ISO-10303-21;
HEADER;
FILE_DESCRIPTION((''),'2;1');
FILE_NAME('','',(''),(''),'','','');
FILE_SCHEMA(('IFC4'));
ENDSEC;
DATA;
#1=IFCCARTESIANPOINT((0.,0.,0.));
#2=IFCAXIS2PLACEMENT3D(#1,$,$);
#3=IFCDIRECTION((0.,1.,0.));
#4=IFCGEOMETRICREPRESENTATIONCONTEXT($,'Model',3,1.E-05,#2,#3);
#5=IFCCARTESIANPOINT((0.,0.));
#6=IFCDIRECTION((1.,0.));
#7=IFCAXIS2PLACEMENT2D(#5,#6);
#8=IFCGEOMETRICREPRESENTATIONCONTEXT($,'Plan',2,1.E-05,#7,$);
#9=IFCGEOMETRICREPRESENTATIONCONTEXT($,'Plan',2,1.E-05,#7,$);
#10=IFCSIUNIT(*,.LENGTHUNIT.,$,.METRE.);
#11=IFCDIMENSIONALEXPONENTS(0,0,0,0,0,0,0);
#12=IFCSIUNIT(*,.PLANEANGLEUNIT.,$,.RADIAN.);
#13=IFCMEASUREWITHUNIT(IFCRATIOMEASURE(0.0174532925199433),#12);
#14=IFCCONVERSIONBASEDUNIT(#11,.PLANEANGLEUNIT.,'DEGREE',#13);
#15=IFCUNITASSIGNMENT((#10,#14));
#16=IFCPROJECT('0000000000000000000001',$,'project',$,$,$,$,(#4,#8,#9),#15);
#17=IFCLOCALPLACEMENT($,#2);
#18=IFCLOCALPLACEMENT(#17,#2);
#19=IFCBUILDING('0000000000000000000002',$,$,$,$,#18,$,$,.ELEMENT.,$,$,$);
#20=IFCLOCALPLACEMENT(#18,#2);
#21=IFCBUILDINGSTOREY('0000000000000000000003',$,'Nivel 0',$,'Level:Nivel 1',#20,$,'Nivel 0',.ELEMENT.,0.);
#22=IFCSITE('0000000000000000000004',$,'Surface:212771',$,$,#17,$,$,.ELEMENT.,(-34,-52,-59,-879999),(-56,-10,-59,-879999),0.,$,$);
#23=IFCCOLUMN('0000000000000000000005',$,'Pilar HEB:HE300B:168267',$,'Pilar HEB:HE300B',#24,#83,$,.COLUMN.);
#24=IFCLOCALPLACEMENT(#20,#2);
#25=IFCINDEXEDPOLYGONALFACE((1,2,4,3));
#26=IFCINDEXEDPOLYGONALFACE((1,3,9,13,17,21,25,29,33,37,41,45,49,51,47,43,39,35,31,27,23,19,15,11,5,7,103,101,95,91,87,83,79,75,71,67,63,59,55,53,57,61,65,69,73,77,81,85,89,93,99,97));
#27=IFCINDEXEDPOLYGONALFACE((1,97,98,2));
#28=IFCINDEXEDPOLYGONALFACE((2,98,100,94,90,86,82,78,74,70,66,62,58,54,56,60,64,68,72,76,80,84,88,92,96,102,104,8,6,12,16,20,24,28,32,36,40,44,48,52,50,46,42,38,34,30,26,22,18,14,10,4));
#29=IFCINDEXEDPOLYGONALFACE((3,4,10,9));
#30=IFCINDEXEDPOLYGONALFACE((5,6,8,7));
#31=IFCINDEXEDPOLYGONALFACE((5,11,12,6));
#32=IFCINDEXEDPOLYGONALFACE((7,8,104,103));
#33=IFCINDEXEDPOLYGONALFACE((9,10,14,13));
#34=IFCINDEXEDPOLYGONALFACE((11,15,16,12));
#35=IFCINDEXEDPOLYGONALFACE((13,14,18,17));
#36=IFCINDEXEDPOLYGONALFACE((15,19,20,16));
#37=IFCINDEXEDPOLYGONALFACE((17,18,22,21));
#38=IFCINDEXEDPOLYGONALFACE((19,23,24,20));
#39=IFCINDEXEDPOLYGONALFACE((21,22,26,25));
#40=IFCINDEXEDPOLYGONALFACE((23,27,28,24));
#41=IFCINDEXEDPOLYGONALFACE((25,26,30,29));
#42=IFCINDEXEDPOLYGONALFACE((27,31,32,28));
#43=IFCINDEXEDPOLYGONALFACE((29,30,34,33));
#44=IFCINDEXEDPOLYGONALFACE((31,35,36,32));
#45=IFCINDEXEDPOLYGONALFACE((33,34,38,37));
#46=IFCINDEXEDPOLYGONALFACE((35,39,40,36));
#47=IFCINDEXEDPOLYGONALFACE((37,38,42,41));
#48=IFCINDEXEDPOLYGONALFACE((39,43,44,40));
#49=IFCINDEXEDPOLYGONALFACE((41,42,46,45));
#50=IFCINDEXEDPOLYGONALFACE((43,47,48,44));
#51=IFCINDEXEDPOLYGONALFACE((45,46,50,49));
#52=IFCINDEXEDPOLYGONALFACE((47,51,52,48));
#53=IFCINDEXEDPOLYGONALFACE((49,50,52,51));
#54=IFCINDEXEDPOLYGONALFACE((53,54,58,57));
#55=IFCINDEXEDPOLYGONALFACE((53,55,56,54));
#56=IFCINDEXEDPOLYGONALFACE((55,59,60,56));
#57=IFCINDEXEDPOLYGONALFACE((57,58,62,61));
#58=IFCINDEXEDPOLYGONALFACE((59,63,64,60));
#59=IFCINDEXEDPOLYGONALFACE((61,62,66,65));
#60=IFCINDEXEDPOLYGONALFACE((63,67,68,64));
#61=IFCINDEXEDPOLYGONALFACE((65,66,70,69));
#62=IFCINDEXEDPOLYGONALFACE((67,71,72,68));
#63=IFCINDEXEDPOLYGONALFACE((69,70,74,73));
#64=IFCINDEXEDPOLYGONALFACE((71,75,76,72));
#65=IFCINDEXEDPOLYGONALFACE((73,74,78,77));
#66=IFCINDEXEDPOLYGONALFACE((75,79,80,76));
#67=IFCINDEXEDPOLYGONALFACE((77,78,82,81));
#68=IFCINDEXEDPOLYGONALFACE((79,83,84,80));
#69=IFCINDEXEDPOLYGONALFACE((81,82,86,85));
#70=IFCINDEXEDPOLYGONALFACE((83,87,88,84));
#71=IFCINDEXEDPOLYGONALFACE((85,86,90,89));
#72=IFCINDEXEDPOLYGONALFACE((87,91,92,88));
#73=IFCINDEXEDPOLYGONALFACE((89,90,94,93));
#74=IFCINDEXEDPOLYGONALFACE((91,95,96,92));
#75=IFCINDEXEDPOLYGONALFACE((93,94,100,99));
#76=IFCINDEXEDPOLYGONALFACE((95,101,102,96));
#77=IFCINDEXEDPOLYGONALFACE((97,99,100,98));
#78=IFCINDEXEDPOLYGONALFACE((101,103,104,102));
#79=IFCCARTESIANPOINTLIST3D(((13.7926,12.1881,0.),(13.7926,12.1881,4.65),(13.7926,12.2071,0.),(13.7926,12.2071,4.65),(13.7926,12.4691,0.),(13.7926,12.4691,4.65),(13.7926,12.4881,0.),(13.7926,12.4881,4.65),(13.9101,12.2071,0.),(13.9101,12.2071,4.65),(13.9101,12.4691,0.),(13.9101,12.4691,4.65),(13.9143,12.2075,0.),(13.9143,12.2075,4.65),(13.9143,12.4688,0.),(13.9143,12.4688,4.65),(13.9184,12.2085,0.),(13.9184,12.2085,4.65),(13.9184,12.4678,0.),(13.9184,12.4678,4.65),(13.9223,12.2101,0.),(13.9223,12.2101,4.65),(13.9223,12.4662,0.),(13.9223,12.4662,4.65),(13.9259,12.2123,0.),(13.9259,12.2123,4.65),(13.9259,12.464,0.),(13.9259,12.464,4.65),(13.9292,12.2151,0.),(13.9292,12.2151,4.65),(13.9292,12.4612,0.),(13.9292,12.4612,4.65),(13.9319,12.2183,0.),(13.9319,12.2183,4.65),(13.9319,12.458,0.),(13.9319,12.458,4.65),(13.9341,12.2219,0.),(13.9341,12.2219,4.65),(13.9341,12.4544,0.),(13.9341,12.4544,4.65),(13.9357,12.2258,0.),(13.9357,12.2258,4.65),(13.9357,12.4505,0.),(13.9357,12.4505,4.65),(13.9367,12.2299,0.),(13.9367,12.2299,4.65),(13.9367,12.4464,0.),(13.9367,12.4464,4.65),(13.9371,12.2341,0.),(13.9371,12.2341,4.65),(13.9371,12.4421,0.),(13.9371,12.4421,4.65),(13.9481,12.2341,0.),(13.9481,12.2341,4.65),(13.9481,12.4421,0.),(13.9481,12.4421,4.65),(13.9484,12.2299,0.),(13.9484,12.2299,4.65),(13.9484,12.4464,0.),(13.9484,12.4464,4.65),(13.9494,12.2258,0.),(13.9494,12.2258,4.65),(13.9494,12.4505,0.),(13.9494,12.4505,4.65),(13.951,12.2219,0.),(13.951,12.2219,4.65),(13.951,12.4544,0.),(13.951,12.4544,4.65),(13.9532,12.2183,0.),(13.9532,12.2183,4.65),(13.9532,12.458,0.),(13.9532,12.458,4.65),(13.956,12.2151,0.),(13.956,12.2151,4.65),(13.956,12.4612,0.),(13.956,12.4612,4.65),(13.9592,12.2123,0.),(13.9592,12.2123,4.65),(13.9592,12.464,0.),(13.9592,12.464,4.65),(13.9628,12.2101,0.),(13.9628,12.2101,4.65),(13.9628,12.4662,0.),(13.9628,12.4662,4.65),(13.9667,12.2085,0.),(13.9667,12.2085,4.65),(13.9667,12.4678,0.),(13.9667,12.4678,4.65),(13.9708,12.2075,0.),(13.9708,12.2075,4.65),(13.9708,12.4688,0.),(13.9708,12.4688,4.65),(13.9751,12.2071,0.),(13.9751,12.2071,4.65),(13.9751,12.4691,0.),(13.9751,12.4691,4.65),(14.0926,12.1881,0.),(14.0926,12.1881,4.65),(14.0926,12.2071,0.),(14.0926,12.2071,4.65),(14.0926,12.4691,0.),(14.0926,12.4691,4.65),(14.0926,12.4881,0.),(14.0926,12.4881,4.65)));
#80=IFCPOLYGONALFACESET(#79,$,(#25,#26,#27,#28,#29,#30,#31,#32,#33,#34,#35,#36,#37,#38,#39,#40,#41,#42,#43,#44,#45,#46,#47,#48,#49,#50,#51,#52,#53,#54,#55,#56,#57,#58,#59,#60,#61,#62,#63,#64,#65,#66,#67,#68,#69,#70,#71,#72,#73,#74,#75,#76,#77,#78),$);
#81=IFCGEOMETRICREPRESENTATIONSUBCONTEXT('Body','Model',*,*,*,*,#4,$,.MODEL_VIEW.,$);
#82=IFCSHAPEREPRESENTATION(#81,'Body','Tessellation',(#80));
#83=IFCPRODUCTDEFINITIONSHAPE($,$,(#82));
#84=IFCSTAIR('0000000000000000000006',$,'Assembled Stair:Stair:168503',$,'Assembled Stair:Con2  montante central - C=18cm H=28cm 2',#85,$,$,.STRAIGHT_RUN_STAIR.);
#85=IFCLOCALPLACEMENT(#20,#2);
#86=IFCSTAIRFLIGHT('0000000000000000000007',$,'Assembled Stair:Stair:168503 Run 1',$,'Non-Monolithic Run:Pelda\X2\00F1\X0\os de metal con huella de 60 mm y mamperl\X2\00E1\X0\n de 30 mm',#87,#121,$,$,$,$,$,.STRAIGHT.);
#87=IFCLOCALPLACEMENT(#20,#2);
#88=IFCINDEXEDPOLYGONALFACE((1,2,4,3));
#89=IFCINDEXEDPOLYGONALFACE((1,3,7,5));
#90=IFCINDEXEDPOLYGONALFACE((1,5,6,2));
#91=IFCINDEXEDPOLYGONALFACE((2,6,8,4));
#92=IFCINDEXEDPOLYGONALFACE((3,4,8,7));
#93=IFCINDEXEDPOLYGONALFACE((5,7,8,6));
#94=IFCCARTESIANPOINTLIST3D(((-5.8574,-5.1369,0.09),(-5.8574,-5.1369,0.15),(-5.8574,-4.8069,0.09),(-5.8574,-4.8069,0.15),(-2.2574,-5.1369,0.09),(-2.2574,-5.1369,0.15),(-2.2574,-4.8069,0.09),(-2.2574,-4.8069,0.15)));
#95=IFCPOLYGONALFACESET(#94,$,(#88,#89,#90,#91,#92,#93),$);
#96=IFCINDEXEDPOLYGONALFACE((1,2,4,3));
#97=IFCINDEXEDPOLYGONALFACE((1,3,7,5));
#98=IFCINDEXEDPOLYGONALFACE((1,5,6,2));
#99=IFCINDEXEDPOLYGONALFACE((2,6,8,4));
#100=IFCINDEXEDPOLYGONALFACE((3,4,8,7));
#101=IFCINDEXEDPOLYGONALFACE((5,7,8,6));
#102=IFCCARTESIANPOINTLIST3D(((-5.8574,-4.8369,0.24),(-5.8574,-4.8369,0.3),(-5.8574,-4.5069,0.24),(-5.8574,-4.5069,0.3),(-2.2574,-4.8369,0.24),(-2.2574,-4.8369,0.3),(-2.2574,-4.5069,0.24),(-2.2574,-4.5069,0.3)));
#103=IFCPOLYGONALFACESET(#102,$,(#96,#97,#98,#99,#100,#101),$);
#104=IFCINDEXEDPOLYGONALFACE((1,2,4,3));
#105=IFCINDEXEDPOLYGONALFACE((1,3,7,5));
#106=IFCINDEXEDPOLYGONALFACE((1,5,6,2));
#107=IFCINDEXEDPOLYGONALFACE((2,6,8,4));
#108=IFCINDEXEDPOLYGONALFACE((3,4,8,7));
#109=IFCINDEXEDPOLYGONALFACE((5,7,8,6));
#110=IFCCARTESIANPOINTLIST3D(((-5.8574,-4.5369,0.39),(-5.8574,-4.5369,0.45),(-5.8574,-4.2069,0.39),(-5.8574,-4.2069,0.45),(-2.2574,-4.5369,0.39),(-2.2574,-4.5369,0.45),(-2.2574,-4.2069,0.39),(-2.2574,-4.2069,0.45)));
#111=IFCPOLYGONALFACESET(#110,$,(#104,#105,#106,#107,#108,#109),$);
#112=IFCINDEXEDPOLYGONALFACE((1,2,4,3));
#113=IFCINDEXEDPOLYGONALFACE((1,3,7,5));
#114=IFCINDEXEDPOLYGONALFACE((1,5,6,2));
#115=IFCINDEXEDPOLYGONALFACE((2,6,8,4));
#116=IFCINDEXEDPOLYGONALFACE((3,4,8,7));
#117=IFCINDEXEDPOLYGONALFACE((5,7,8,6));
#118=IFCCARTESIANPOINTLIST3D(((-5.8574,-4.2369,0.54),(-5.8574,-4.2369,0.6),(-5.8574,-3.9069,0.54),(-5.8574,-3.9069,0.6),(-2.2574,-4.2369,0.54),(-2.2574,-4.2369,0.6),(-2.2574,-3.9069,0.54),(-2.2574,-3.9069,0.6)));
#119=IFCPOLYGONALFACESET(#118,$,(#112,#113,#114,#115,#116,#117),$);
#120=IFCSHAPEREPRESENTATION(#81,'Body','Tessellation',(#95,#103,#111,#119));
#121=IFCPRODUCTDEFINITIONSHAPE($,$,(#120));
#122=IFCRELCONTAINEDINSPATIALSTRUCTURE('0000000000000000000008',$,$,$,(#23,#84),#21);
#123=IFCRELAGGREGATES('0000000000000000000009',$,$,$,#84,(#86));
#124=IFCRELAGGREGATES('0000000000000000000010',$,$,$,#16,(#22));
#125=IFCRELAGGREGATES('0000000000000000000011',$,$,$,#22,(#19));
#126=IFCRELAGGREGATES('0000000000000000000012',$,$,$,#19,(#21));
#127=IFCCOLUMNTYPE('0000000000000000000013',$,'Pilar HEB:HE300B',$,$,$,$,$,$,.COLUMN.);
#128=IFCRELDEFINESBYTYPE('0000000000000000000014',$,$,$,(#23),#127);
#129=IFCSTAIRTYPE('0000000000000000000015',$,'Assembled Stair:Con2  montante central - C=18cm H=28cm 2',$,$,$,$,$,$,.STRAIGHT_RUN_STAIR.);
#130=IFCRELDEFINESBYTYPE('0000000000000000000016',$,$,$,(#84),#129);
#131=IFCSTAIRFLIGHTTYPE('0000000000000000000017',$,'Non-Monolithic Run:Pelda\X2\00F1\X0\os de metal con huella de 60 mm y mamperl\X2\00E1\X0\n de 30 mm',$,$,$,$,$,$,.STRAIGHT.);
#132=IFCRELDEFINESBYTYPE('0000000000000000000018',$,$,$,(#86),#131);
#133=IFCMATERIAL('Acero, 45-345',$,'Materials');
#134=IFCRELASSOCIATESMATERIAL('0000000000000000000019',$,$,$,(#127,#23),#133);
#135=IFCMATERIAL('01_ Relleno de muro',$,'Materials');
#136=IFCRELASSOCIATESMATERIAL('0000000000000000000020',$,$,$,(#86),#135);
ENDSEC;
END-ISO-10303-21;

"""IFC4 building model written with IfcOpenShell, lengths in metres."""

from ifc_helpers import new_model, entity, si_unit, converted_unit, direction, frame, origin, origin_2d_with_axis, place, context, subcontext, project, spatial, polyline, indexed_curve, outline, extrude, source, transform, mapped, material, type_object, type_shapes, element, aggregate, save


model = new_model("IFC4")

# Units and contexts
model_context = context("Model", 3, precision=1e-05, world=origin(), true_north=direction((0.0, 1.0, 0.0)))
plan_context_1 = context("Plan", 2, precision=1e-05, world=origin_2d_with_axis())
plan_context_2 = context("Plan", 2, precision=1e-05, world=origin_2d_with_axis())
body_context = subcontext(model_context, "Body", "Model", "MODEL_VIEW")
ifc_project = project(units=[si_unit("LENGTHUNIT", "METRE"), converted_unit("PLANEANGLEUNIT", "DEGREE", entity("IfcRatioMeasure", 0.0174532925199433), si_unit("PLANEANGLEUNIT", "RADIAN"), dimensions=[0, 0, 0, 0, 0, 0, 0])], contexts=[model_context, plan_context_1, plan_context_2])

# Site, building, storey
site_placement = place(None, origin())
site = spatial("IfcSite", under=ifc_project, at=site_placement, Name="Surface:212771", CompositionType="ELEMENT", RefLatitude=(-34, -52, -59, -879999), RefLongitude=(-56, -10, -59, -879999), RefElevation=0.0)
building_placement = place(site_placement, origin())
building = spatial("IfcBuilding", under=site, at=building_placement, CompositionType="ELEMENT")
storey_placement = place(building_placement, origin())
storey = spatial("IfcBuildingStorey", under=building, at=storey_placement, Name="Nivel 0", ObjectType="Level:Nivel 1", LongName="Nivel 0", CompositionType="ELEMENT", Elevation=0.0)

# Column
ifc_material_1 = material(Name="Acero, 45-345", Category="Materials")
column_type_1 = type_object("IfcColumnType", Name="Pilar HEB:HE300B", PredefinedType="COLUMN", material=ifc_material_1)
shared_shape_1 = source(origin(), body_context, "Body", "SweptSolid", [
    extrude(outline(polyline([(0.1041, 0.0), (0.1084, -0.0001), (0.1125, -0.0009), (0.1165, -0.0023), (0.1203, -0.0043), (0.1236, -0.0069), (0.1265, -0.01), (0.1289, -0.0135), (0.1308, -0.0173), (0.132, -0.0213), (0.1325, -0.0255), (0.1387, -0.1429), (0.1577, -0.1419), (0.1419, 0.1577), (0.1229, 0.1567), (0.1291, 0.0394), (0.129, 0.0351), (0.1282, 0.031), (0.1268, 0.027), (0.1248, 0.0233), (0.1222, 0.0199), (0.1191, 0.017), (0.1156, 0.0146), (0.1118, 0.0127), (0.1078, 0.0115), (0.1036, 0.011), (-0.1041, 0.0), (-0.1084, 0.0001), (-0.1125, 0.0009), (-0.1165, 0.0023), (-0.1203, 0.0043), (-0.1236, 0.0069), (-0.1265, 0.01), (-0.1289, 0.0135), (-0.1308, 0.0173), (-0.132, 0.0213), (-0.1325, 0.0255), (-0.1387, 0.1429), (-0.1577, 0.1419), (-0.1419, -0.1577), (-0.1229, -0.1567), (-0.1291, -0.0394), (-0.129, -0.0351), (-0.1282, -0.031), (-0.1268, -0.027), (-0.1248, -0.0233), (-0.1222, -0.0199), (-0.1191, -0.017), (-0.1156, -0.0146), (-0.1118, -0.0127), (-0.1078, -0.0115), (-0.1036, -0.011), (0.1041, 0.0)])), frame((0.0, 0.0, 0.0), z_axis=(0.0, 0.0, -1.0), x_axis=(0.052811, -0.998605, 0.0)), (0.0, 0.0, -1.0), 4.65),
])
type_shapes(column_type_1, [shared_shape_1])
for number, where, z_axis, x_axis, name in (
    (1, (13.9426, 12.3381, 0.0), (0.0, 0.0, 2.119702), (1.0, 0.0, 0.0), "Pilar HEB:HE300B:168267"),
):
    element("IfcColumn", number, at=place(storey_placement, frame(where, z_axis=z_axis, x_axis=x_axis)), inside=storey, type_object=column_type_1, material=ifc_material_1, Name=name, ObjectType="Pilar HEB:HE300B", PredefinedType="COLUMN", context=body_context, shape_type="MappedRepresentation", body=[
        mapped(shared_shape_1, transform((0.0, 0.0, 0.0), scale=1.0)),
    ])

# Stair, stair flight
stair_type = type_object("IfcStairType", Name="Assembled Stair:Con2  montante central - C=18cm H=28cm 2", PredefinedType="STRAIGHT_RUN_STAIR")
stair_placement = place(storey_placement, origin())
stair = element("IfcStair", 2, at=stair_placement, inside=storey, type_object=stair_type, Name="Assembled Stair:Stair:168503", ObjectType="Assembled Stair:Con2  montante central - C=18cm H=28cm 2", PredefinedType="STRAIGHT_RUN_STAIR")
ifc_material_2 = material(Name="01_ Relleno de muro", Category="Materials")
stair_flight_type = type_object("IfcStairFlightType", Name="Non-Monolithic Run:Peldaños de metal con huella de 60 mm y mamperlán de 30 mm", PredefinedType="STRAIGHT")
stair_flight_placement = place(stair_placement, origin())
stair_flight = element("IfcStairFlight", 3, at=stair_flight_placement, type_object=stair_flight_type, material=ifc_material_2, Name="Assembled Stair:Stair:168503 Run 1", ObjectType="Non-Monolithic Run:Peldaños de metal con huella de 60 mm y mamperlán de 30 mm", PredefinedType="STRAIGHT", context=body_context, shape_type="SweptSolid", body=[
    extrude(outline(indexed_curve([(-0.165, -1.8), (0.165, -1.8), (0.165, 1.8), (-0.165, 1.8), (-0.165, -1.8)], self_intersect=False)), frame((-4.0574, -4.9719, 0.09), z_axis=(0.0, 0.0, 1.0), x_axis=(0.0, -1.0, 0.0)), (0.0, 0.0, 1.0), 0.06),
    extrude(outline(indexed_curve([(-0.165, -1.8), (0.165, -1.8), (0.165, 1.8), (-0.165, 1.8), (-0.165, -1.8)], self_intersect=False)), frame((-4.0574, -4.6719, 0.24), z_axis=(0.0, 0.0, 1.0), x_axis=(0.0, -1.0, 0.0)), (0.0, 0.0, 1.0), 0.06),
    extrude(outline(indexed_curve([(-0.165, -1.8), (0.165, -1.8), (0.165, 1.8), (-0.165, 1.8), (-0.165, -1.8)], self_intersect=False)), frame((-4.0574, -4.3719, 0.39), z_axis=(0.0, 0.0, 1.0), x_axis=(0.0, -1.0, 0.0)), (0.0, 0.0, 1.0), 0.06),
    extrude(outline(indexed_curve([(-0.165, -1.8), (0.165, -1.8), (0.165, 1.8), (-0.165, 1.8), (-0.165, -1.8)], self_intersect=False)), frame((-4.0574, -4.0719, 0.54), z_axis=(0.0, 0.0, 1.0), x_axis=(0.0, -1.0, 0.0)), (0.0, 0.0, 1.0), 0.06),
])
aggregate(stair, [stair_flight])

save(model, "model.ifc")
